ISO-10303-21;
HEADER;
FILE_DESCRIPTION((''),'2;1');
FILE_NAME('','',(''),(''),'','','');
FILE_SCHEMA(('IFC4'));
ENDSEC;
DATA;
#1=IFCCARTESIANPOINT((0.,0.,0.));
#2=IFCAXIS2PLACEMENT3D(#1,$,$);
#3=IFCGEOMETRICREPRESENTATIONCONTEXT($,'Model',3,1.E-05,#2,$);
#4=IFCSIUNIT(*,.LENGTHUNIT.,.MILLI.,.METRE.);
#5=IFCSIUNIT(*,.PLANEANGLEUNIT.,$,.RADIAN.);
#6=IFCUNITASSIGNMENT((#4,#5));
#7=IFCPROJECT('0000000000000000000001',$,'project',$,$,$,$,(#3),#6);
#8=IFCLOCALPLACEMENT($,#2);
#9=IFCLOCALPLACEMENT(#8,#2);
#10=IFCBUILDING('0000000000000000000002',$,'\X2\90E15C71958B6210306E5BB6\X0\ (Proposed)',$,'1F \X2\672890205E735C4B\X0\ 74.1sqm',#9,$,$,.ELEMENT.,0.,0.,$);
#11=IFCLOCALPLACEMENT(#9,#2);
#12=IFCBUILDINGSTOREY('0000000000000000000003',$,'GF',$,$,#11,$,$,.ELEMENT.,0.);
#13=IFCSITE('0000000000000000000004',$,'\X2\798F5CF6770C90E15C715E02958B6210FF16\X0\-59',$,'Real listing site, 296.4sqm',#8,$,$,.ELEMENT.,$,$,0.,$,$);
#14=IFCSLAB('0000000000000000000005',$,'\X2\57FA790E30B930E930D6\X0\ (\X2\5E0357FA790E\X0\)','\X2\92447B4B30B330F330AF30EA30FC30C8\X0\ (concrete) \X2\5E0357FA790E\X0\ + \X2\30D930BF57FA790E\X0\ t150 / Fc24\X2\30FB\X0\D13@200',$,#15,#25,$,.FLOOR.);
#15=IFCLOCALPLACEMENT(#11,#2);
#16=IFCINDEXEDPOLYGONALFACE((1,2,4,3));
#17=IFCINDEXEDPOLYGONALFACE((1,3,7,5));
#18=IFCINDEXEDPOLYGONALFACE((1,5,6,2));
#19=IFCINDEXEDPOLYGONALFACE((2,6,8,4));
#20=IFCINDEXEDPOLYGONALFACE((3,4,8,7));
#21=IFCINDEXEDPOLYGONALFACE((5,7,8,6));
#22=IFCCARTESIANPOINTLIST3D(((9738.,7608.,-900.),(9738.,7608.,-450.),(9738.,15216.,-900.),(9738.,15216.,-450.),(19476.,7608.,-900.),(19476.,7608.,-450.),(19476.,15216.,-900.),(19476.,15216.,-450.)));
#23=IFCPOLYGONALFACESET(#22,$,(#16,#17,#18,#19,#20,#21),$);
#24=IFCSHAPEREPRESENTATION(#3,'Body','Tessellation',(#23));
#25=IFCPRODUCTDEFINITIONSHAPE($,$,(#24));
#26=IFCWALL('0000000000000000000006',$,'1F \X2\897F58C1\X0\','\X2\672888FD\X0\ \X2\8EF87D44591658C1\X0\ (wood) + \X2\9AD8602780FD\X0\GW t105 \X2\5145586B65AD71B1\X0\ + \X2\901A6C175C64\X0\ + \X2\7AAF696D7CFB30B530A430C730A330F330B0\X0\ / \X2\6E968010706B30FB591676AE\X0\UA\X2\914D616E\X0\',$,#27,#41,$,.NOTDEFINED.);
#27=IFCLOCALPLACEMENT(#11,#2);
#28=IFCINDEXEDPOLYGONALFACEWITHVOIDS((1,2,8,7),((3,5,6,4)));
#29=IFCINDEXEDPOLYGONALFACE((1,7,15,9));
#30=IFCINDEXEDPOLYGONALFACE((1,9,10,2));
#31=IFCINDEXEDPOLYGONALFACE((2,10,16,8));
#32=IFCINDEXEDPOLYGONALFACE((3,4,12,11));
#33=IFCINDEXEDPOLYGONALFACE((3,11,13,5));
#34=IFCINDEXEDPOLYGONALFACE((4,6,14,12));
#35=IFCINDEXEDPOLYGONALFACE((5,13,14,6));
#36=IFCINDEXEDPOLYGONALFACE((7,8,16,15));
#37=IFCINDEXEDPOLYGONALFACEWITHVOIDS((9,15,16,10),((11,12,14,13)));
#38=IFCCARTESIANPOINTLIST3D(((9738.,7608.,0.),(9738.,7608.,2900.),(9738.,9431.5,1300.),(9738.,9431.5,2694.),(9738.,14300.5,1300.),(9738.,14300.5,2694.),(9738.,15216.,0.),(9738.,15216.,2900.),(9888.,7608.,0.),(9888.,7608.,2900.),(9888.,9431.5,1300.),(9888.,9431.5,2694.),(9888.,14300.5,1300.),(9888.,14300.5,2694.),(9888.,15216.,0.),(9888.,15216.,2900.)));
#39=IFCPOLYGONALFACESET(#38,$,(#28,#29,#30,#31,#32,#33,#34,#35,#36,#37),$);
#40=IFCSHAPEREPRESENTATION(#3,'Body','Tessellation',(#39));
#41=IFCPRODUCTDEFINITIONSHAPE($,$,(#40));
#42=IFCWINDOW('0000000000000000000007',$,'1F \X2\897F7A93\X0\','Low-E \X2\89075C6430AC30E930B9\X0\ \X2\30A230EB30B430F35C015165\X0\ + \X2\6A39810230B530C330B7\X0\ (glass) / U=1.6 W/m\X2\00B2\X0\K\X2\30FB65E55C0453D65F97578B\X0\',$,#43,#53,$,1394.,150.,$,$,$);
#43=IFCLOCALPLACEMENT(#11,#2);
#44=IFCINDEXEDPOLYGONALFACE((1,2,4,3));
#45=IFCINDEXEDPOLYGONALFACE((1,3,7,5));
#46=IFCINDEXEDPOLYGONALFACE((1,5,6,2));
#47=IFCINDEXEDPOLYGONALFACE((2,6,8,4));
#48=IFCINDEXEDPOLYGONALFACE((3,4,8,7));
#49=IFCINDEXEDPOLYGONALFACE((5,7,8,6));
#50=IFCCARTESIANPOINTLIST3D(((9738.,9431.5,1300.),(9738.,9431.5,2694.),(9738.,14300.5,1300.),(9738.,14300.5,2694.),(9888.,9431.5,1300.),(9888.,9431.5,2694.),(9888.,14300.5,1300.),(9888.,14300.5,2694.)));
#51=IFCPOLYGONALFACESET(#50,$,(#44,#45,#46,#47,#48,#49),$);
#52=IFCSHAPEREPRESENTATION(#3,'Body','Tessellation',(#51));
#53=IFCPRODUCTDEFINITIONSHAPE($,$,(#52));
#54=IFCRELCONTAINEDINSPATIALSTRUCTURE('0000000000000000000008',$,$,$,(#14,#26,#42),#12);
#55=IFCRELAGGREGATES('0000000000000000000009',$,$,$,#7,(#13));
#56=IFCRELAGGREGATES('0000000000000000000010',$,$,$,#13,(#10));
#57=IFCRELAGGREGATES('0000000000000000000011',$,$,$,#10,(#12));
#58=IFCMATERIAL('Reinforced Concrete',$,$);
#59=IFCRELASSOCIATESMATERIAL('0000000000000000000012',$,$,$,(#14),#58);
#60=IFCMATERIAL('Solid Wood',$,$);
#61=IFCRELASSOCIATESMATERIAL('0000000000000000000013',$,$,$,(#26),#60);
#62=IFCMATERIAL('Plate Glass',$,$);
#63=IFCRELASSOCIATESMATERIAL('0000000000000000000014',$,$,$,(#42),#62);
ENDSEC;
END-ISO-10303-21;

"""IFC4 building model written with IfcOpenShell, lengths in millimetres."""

from ifc_helpers import new_model, si_unit, frame, frame_2d, origin, place, context, project, spatial, rectangle, extrude, material, element, fill, save


model = new_model("IFC4")

# Units and contexts
model_context = context("Model", 3, precision=1e-05, world=origin())
ifc_project = project(units=[si_unit("LENGTHUNIT", "METRE", prefix="MILLI"), si_unit("PLANEANGLEUNIT", "RADIAN")], contexts=[model_context])

# Site, building, storey
site_placement = place(None, origin())
site = spatial("IfcSite", under=ifc_project, at=site_placement, Name="福島県郡山市開成６-59", ObjectType="Real listing site, 296.4sqm", CompositionType="ELEMENT", RefElevation=0.0)
building_placement = place(site_placement, origin())
building = spatial("IfcBuilding", under=site, at=building_placement, Name="郡山開成の家 (Proposed)", ObjectType="1F 木造平屋 74.1sqm", CompositionType="ELEMENT", ElevationOfRefHeight=0.0, ElevationOfTerrain=0.0)
storey_placement = place(building_placement, origin())
storey = spatial("IfcBuildingStorey", under=building, at=storey_placement, Name="GF", CompositionType="ELEMENT", Elevation=0.0)

# Slab
ifc_material_1 = material(Name="Reinforced Concrete")
slab_1_placement = place(storey_placement, frame((4869.0, 3804.0, -450.0)))
element("IfcSlab", 1, at=slab_1_placement, inside=storey, material=ifc_material_1, Name="基礎スラブ (布基礎)", Description="鉄筋コンクリート (concrete) 布基礎 + ベタ基礎 t150 / Fc24・D13@200", PredefinedType="FLOOR", context=model_context, shape_type="SweptSolid", body=[
    extrude(rectangle(XDim=9738.0, YDim=7608.0, at=frame_2d((4869.0, 3804.0))), frame((4869.0, 3804.0, -450.0)), (0.0, 0.0, 1.0), 450.0),
])
ifc_material_2 = material(Name="Solid Wood")

# Shared definitions
ifc_material_3 = material(Name="Plate Glass")

# Wall, opening, window
wall_1_placement = place(storey_placement, frame((4869.0, 3804.0, 0.0)))
wall_1 = element("IfcWall", 2, at=wall_1_placement, inside=storey, material=ifc_material_2, Name="1F 西壁", Description="木製 軸組外壁 (wood) + 高性能GW t105 充填断熱 + 通気層 + 窯業系サイディング / 準耐火・外皮UA配慮", PredefinedType="NOTDEFINED", context=model_context, shape_type="SweptSolid", body=[
    extrude(rectangle(XDim=150.0, YDim=7608.0, at=frame_2d((75.0, 3804.0))), frame((4869.0, 3804.0, 0.0)), (0.0, 0.0, 1.0), 2900.0),
])
opening_1_placement = place(storey_placement, frame((4869.0, 4716.0, 650.0)))
opening_1 = element("IfcOpeningElement", 3, at=opening_1_placement, cuts=wall_1, PredefinedType="NOTDEFINED", context=model_context, shape_type="SweptSolid", body=[
    extrude(rectangle(XDim=150.0, YDim=4869.0, at=frame_2d((75.0, 2434.0))), frame((4869.0, 4716.0, 650.0)), (0.0, 0.0, 1.0), 1394.0),
])
window_1_placement = place(storey_placement, frame((4869.0, 4716.0, 650.0)))
window_1 = element("IfcWindow", 4, at=window_1_placement, inside=storey, material=ifc_material_3, Name="1F 西窓", Description="Low-E 複層ガラス アルゴン封入 + 樹脂サッシ (glass) / U=1.6 W/m²K・日射取得型", OverallHeight=1394.0, OverallWidth=150.0, context=model_context, shape_type="SweptSolid", body=[
    extrude(rectangle(XDim=150.0, YDim=4869.0, at=frame_2d((75.0, 2434.0))), frame((4869.0, 4716.0, 650.0)), (0.0, 0.0, 1.0), 1394.0),
])
fill(opening_1, window_1)

save(model, "model.ifc")
